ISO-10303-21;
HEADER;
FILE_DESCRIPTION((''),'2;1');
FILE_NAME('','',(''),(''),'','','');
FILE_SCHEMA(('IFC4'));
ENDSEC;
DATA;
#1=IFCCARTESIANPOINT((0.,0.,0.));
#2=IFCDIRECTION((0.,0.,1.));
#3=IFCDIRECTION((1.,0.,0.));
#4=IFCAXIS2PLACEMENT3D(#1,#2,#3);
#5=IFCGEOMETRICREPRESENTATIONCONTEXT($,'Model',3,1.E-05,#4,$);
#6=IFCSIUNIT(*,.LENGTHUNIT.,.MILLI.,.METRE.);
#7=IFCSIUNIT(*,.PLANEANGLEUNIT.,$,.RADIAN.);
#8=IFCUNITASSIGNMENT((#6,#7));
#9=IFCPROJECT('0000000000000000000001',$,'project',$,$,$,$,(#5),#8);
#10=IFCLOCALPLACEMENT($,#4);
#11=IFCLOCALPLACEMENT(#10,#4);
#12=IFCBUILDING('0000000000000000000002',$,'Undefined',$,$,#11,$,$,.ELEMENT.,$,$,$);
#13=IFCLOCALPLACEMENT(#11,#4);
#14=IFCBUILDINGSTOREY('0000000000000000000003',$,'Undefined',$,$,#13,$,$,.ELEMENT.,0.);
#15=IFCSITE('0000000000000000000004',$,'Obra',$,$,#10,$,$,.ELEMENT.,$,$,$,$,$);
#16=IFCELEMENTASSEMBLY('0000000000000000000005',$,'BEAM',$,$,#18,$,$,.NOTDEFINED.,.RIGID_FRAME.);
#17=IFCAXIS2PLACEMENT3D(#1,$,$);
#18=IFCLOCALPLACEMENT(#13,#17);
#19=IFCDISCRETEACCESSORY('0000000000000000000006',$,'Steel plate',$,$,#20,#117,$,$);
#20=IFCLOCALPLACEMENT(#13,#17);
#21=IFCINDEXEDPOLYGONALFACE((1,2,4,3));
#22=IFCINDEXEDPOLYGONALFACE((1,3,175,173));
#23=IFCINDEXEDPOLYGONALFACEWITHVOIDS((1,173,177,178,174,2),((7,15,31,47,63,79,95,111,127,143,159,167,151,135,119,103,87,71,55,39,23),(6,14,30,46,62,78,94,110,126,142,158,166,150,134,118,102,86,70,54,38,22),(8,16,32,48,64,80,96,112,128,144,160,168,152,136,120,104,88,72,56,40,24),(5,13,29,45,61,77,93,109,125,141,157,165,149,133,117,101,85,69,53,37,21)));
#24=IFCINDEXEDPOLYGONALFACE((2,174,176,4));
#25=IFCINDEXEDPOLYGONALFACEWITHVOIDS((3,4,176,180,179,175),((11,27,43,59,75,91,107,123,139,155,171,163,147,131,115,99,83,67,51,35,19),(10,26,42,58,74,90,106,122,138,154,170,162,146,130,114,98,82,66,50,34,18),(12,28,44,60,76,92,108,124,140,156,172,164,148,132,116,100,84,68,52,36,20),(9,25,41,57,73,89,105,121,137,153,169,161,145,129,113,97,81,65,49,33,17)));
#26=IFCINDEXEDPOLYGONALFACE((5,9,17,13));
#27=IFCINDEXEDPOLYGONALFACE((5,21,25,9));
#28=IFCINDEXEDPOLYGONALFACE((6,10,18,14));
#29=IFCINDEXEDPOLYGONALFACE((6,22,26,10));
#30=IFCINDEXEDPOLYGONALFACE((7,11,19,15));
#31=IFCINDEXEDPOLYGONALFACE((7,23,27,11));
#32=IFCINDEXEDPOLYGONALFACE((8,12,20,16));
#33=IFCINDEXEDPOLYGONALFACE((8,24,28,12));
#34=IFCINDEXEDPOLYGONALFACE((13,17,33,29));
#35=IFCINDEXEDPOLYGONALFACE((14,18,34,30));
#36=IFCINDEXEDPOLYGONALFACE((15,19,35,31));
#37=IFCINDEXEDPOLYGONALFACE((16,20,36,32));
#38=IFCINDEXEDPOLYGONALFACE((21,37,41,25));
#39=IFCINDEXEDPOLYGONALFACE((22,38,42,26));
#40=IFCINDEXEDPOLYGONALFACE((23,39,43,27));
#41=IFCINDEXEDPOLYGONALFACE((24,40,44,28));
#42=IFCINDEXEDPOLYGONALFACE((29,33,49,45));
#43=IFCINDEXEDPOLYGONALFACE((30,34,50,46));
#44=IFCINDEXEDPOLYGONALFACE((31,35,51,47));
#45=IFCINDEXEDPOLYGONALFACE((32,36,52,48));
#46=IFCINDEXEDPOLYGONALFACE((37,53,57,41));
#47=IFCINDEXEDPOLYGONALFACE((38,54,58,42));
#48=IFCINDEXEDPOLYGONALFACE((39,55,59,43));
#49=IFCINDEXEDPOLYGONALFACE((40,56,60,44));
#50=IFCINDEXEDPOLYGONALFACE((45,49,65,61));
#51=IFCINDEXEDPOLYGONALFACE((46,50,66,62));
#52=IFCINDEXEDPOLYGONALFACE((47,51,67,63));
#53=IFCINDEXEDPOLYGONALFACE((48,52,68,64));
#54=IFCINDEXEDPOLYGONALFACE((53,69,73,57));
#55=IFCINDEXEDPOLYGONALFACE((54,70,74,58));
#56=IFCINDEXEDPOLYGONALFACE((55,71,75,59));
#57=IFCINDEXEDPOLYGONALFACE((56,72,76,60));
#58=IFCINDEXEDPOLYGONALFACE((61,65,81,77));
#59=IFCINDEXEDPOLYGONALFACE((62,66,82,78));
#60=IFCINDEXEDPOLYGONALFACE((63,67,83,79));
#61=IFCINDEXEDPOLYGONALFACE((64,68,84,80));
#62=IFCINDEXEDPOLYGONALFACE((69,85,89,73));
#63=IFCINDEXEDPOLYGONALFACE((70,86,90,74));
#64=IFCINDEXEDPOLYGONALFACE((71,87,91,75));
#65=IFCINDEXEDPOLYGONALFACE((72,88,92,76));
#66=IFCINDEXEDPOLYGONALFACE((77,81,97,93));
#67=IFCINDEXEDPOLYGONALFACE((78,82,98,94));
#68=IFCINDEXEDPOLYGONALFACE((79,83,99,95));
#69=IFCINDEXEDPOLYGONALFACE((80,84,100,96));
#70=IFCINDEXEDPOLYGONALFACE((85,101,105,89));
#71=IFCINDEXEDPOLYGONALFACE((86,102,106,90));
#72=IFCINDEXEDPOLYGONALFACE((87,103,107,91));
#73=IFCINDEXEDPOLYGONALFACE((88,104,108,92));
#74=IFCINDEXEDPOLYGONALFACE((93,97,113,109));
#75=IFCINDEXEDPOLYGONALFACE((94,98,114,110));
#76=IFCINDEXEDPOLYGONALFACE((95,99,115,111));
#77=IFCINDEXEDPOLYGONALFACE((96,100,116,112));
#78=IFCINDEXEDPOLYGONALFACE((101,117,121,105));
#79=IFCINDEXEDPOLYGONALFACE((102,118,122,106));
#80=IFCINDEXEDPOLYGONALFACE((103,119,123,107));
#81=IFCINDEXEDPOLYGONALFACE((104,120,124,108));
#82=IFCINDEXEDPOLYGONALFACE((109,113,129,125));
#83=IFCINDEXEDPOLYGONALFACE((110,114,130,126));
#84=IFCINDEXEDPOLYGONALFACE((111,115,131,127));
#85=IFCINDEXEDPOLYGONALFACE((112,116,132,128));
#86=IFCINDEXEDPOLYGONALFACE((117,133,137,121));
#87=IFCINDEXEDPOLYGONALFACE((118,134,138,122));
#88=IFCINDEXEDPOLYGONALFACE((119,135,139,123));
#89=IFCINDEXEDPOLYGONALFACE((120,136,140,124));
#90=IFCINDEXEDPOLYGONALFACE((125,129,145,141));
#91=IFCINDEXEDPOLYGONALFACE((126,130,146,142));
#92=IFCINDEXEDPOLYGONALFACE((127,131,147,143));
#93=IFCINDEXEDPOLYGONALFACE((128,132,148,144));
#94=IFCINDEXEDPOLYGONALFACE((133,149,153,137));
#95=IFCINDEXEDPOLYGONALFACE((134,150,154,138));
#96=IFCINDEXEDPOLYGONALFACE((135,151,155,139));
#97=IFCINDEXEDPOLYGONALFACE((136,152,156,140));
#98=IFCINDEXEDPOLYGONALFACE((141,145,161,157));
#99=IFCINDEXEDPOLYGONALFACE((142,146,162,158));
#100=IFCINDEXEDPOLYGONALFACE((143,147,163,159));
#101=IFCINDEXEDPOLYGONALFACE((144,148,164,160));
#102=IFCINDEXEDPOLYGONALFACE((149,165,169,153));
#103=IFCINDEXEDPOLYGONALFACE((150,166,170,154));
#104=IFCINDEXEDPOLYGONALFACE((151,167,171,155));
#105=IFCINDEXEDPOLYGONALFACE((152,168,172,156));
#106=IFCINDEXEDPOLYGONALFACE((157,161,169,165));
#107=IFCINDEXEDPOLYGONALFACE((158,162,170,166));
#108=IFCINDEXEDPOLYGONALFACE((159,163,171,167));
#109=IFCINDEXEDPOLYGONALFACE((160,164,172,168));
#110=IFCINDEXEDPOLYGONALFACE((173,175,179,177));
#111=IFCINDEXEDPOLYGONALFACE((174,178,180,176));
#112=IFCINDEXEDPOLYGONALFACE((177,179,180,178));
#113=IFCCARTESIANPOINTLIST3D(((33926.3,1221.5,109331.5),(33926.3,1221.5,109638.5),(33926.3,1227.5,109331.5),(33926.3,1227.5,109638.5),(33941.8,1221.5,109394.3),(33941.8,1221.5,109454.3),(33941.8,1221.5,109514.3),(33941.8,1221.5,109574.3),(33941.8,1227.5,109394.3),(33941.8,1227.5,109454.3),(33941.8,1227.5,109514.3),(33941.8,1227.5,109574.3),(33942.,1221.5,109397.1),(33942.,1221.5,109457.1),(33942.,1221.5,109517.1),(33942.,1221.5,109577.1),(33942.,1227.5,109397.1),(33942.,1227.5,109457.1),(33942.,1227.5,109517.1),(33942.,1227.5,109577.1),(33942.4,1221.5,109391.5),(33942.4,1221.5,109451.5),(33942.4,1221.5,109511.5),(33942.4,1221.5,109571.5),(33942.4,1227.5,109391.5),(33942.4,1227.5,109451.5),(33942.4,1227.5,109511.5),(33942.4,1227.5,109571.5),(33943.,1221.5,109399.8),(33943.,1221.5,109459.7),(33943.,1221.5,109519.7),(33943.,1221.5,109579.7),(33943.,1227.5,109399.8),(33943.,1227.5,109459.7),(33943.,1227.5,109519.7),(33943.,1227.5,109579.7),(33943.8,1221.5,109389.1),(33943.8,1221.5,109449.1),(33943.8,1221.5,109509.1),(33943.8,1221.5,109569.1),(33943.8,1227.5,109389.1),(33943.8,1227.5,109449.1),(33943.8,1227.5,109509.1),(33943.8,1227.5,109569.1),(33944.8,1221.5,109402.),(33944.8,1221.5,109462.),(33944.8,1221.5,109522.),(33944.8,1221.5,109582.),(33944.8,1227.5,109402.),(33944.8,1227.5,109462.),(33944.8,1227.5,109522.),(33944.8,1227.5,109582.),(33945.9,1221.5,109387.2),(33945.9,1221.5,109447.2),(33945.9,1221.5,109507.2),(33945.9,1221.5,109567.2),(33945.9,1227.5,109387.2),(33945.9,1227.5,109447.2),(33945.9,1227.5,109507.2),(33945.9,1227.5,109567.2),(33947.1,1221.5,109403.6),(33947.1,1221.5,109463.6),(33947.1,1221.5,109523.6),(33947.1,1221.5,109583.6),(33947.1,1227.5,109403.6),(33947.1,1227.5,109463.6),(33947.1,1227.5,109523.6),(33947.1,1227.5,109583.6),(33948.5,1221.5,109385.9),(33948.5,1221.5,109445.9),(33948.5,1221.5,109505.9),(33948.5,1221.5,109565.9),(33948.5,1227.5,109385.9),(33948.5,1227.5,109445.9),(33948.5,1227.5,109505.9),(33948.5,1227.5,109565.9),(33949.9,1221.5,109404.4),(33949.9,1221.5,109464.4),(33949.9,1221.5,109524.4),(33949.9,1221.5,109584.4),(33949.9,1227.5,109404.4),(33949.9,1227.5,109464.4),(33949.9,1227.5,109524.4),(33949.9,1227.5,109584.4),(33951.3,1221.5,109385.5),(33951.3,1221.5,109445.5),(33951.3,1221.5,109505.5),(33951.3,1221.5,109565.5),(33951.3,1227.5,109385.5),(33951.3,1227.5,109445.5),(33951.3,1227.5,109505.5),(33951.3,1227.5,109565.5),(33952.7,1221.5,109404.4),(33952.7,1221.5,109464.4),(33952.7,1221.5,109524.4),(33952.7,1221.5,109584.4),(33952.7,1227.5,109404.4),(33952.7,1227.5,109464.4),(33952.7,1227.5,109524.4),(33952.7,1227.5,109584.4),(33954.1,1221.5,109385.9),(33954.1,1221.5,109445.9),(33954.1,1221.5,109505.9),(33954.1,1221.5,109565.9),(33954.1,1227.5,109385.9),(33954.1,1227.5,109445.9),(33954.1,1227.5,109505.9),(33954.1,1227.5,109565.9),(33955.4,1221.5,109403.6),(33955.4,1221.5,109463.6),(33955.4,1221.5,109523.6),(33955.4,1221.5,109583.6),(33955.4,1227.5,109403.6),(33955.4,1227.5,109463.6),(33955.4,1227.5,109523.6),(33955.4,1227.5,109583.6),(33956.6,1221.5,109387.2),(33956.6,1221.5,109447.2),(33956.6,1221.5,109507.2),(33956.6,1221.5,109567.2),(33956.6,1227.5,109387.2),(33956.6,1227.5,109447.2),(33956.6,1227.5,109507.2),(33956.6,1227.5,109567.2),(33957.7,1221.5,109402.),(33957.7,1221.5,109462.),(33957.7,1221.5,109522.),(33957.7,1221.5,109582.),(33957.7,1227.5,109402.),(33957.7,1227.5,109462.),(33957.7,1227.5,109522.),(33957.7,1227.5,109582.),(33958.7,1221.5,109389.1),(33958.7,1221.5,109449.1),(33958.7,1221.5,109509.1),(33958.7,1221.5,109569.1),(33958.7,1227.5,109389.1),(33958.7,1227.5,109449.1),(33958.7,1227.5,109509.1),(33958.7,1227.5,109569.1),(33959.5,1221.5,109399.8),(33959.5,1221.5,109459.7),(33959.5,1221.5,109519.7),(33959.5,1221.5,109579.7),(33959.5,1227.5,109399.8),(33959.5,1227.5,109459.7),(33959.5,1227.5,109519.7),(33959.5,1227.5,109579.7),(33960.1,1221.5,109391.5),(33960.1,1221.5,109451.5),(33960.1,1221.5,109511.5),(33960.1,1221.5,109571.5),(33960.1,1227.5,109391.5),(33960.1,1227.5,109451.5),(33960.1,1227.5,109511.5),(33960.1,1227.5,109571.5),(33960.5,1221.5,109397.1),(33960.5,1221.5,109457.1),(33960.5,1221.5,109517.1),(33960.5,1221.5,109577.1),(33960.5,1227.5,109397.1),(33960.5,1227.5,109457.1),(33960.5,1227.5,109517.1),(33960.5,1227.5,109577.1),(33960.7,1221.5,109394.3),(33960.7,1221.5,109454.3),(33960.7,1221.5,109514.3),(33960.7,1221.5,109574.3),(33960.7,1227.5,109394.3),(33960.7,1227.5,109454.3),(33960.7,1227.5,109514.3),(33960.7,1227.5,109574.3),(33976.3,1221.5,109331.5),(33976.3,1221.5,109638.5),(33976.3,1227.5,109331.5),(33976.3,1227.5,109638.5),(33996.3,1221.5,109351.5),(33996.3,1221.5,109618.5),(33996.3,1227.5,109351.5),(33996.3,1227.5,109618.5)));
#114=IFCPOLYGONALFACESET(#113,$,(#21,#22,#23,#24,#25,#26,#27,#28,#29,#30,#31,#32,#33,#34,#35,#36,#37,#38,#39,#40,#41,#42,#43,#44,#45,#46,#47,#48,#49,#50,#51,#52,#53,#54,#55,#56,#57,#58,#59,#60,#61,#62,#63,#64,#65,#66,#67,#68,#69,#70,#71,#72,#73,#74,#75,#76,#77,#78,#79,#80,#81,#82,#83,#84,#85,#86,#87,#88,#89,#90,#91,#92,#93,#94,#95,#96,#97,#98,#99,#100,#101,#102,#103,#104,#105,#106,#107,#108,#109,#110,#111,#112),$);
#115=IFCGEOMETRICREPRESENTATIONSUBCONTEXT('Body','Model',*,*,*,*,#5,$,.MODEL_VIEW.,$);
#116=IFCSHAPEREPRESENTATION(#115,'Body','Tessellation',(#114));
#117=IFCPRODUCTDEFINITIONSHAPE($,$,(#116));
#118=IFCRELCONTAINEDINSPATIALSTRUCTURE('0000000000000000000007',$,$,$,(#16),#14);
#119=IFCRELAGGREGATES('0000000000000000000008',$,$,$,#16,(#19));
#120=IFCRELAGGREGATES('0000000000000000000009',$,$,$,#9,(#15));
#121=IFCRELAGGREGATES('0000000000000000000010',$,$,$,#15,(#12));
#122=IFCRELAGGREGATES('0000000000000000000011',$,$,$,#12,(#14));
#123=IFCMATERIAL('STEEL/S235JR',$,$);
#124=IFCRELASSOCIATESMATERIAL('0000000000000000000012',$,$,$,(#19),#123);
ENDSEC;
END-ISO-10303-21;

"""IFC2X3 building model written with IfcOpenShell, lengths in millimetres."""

from ifc_helpers import new_model, si_unit, frame, origin_with_axes, origin_2d_with_axis, place, context, subcontext, project, spatial, polyline, circle, outline, extrude, source, transform, mapped, material, element, aggregate, save


model = new_model("IFC2X3")

# Units and contexts
model_context = context("Model", 3, precision=1e-05, world=origin_with_axes())
body_context = subcontext(model_context, "Body", "Model", "MODEL_VIEW")
ifc_project = project(units=[si_unit("LENGTHUNIT", "METRE", prefix="MILLI"), si_unit("PLANEANGLEUNIT", "RADIAN")], contexts=[model_context])

# Site, building, storey
site_placement = place(None, origin_with_axes())
site = spatial("IfcSite", under=ifc_project, at=site_placement, Name="Obra", CompositionType="ELEMENT")
building_placement = place(site_placement, origin_with_axes())
building = spatial("IfcBuilding", under=site, at=building_placement, Name="Undefined", CompositionType="ELEMENT")
storey_placement = place(building_placement, origin_with_axes())
storey = spatial("IfcBuildingStorey", under=building, at=storey_placement, Name="Undefined", CompositionType="ELEMENT", Elevation=0.0)

# Element assembly, discrete accessory, opening
assembly_1_placement = place(storey_placement, origin_with_axes())
assembly_1 = element("IfcElementAssembly", 1, at=assembly_1_placement, inside=storey, Name="BEAM", AssemblyPlace="NOTDEFINED", PredefinedType="RIGID_FRAME")
ifc_material = material(Name="STEEL/S235JR")
discrete_accessory_1_placement = place(assembly_1_placement, frame((33926.3, 1224.5, 109331.5), z_axis=(0.000002, -1.0, 0.0), x_axis=(1.0, 0.000002, 0.0)))
discrete_accessory_1 = element("IfcDiscreteAccessory", 2, at=discrete_accessory_1_placement, material=ifc_material, Name="Steel plate", context=body_context, shape_type="SweptSolid", body=[
    extrude(outline(polyline([(0.0, 0.0), (50.0, 0.0), (70.0, 20.0), (70.0, 287.0), (50.0, 307.0), (0.0, 307.0), (0.0, 0.0)])), frame((0.0, 0.0, -3.0), z_axis=(0.0, 0.0, 1.0), x_axis=(1.0, 0.0, 0.0)), (0.0, 0.0, 1.0), 6.0),
])
shared_shape = source(origin_with_axes(), body_context, "Body", "SweptSolid", [
    extrude(circle(Radius=9.5, at=origin_2d_with_axis()), frame((0.0, -9.8, 0.0), z_axis=(0.0, 1.0, 0.0), x_axis=(1.0, 0.0, 0.0)), (0.0, 0.0, 1.0), 6.2),
])
opening_1_placement = place(assembly_1_placement, frame((33986.3, 1217.7, 109650.0), z_axis=(-1.0, -0.000002, 0.0), x_axis=(0.0, 0.0, -1.0)))
element("IfcOpeningElement", 3, at=opening_1_placement, cuts=discrete_accessory_1, ObjectType="Opening", context=body_context, shape_type="MappedRepresentation", body=[
    mapped(shared_shape, transform((75.0, 0.0, 35.0))),
    mapped(shared_shape, transform((135.0, 0.0, 35.0))),
    mapped(shared_shape, transform((195.0, 0.0, 35.0))),
    mapped(shared_shape, transform((255.0, 0.0, 35.0))),
])
aggregate(assembly_1, [discrete_accessory_1])

save(model, "model.ifc")
